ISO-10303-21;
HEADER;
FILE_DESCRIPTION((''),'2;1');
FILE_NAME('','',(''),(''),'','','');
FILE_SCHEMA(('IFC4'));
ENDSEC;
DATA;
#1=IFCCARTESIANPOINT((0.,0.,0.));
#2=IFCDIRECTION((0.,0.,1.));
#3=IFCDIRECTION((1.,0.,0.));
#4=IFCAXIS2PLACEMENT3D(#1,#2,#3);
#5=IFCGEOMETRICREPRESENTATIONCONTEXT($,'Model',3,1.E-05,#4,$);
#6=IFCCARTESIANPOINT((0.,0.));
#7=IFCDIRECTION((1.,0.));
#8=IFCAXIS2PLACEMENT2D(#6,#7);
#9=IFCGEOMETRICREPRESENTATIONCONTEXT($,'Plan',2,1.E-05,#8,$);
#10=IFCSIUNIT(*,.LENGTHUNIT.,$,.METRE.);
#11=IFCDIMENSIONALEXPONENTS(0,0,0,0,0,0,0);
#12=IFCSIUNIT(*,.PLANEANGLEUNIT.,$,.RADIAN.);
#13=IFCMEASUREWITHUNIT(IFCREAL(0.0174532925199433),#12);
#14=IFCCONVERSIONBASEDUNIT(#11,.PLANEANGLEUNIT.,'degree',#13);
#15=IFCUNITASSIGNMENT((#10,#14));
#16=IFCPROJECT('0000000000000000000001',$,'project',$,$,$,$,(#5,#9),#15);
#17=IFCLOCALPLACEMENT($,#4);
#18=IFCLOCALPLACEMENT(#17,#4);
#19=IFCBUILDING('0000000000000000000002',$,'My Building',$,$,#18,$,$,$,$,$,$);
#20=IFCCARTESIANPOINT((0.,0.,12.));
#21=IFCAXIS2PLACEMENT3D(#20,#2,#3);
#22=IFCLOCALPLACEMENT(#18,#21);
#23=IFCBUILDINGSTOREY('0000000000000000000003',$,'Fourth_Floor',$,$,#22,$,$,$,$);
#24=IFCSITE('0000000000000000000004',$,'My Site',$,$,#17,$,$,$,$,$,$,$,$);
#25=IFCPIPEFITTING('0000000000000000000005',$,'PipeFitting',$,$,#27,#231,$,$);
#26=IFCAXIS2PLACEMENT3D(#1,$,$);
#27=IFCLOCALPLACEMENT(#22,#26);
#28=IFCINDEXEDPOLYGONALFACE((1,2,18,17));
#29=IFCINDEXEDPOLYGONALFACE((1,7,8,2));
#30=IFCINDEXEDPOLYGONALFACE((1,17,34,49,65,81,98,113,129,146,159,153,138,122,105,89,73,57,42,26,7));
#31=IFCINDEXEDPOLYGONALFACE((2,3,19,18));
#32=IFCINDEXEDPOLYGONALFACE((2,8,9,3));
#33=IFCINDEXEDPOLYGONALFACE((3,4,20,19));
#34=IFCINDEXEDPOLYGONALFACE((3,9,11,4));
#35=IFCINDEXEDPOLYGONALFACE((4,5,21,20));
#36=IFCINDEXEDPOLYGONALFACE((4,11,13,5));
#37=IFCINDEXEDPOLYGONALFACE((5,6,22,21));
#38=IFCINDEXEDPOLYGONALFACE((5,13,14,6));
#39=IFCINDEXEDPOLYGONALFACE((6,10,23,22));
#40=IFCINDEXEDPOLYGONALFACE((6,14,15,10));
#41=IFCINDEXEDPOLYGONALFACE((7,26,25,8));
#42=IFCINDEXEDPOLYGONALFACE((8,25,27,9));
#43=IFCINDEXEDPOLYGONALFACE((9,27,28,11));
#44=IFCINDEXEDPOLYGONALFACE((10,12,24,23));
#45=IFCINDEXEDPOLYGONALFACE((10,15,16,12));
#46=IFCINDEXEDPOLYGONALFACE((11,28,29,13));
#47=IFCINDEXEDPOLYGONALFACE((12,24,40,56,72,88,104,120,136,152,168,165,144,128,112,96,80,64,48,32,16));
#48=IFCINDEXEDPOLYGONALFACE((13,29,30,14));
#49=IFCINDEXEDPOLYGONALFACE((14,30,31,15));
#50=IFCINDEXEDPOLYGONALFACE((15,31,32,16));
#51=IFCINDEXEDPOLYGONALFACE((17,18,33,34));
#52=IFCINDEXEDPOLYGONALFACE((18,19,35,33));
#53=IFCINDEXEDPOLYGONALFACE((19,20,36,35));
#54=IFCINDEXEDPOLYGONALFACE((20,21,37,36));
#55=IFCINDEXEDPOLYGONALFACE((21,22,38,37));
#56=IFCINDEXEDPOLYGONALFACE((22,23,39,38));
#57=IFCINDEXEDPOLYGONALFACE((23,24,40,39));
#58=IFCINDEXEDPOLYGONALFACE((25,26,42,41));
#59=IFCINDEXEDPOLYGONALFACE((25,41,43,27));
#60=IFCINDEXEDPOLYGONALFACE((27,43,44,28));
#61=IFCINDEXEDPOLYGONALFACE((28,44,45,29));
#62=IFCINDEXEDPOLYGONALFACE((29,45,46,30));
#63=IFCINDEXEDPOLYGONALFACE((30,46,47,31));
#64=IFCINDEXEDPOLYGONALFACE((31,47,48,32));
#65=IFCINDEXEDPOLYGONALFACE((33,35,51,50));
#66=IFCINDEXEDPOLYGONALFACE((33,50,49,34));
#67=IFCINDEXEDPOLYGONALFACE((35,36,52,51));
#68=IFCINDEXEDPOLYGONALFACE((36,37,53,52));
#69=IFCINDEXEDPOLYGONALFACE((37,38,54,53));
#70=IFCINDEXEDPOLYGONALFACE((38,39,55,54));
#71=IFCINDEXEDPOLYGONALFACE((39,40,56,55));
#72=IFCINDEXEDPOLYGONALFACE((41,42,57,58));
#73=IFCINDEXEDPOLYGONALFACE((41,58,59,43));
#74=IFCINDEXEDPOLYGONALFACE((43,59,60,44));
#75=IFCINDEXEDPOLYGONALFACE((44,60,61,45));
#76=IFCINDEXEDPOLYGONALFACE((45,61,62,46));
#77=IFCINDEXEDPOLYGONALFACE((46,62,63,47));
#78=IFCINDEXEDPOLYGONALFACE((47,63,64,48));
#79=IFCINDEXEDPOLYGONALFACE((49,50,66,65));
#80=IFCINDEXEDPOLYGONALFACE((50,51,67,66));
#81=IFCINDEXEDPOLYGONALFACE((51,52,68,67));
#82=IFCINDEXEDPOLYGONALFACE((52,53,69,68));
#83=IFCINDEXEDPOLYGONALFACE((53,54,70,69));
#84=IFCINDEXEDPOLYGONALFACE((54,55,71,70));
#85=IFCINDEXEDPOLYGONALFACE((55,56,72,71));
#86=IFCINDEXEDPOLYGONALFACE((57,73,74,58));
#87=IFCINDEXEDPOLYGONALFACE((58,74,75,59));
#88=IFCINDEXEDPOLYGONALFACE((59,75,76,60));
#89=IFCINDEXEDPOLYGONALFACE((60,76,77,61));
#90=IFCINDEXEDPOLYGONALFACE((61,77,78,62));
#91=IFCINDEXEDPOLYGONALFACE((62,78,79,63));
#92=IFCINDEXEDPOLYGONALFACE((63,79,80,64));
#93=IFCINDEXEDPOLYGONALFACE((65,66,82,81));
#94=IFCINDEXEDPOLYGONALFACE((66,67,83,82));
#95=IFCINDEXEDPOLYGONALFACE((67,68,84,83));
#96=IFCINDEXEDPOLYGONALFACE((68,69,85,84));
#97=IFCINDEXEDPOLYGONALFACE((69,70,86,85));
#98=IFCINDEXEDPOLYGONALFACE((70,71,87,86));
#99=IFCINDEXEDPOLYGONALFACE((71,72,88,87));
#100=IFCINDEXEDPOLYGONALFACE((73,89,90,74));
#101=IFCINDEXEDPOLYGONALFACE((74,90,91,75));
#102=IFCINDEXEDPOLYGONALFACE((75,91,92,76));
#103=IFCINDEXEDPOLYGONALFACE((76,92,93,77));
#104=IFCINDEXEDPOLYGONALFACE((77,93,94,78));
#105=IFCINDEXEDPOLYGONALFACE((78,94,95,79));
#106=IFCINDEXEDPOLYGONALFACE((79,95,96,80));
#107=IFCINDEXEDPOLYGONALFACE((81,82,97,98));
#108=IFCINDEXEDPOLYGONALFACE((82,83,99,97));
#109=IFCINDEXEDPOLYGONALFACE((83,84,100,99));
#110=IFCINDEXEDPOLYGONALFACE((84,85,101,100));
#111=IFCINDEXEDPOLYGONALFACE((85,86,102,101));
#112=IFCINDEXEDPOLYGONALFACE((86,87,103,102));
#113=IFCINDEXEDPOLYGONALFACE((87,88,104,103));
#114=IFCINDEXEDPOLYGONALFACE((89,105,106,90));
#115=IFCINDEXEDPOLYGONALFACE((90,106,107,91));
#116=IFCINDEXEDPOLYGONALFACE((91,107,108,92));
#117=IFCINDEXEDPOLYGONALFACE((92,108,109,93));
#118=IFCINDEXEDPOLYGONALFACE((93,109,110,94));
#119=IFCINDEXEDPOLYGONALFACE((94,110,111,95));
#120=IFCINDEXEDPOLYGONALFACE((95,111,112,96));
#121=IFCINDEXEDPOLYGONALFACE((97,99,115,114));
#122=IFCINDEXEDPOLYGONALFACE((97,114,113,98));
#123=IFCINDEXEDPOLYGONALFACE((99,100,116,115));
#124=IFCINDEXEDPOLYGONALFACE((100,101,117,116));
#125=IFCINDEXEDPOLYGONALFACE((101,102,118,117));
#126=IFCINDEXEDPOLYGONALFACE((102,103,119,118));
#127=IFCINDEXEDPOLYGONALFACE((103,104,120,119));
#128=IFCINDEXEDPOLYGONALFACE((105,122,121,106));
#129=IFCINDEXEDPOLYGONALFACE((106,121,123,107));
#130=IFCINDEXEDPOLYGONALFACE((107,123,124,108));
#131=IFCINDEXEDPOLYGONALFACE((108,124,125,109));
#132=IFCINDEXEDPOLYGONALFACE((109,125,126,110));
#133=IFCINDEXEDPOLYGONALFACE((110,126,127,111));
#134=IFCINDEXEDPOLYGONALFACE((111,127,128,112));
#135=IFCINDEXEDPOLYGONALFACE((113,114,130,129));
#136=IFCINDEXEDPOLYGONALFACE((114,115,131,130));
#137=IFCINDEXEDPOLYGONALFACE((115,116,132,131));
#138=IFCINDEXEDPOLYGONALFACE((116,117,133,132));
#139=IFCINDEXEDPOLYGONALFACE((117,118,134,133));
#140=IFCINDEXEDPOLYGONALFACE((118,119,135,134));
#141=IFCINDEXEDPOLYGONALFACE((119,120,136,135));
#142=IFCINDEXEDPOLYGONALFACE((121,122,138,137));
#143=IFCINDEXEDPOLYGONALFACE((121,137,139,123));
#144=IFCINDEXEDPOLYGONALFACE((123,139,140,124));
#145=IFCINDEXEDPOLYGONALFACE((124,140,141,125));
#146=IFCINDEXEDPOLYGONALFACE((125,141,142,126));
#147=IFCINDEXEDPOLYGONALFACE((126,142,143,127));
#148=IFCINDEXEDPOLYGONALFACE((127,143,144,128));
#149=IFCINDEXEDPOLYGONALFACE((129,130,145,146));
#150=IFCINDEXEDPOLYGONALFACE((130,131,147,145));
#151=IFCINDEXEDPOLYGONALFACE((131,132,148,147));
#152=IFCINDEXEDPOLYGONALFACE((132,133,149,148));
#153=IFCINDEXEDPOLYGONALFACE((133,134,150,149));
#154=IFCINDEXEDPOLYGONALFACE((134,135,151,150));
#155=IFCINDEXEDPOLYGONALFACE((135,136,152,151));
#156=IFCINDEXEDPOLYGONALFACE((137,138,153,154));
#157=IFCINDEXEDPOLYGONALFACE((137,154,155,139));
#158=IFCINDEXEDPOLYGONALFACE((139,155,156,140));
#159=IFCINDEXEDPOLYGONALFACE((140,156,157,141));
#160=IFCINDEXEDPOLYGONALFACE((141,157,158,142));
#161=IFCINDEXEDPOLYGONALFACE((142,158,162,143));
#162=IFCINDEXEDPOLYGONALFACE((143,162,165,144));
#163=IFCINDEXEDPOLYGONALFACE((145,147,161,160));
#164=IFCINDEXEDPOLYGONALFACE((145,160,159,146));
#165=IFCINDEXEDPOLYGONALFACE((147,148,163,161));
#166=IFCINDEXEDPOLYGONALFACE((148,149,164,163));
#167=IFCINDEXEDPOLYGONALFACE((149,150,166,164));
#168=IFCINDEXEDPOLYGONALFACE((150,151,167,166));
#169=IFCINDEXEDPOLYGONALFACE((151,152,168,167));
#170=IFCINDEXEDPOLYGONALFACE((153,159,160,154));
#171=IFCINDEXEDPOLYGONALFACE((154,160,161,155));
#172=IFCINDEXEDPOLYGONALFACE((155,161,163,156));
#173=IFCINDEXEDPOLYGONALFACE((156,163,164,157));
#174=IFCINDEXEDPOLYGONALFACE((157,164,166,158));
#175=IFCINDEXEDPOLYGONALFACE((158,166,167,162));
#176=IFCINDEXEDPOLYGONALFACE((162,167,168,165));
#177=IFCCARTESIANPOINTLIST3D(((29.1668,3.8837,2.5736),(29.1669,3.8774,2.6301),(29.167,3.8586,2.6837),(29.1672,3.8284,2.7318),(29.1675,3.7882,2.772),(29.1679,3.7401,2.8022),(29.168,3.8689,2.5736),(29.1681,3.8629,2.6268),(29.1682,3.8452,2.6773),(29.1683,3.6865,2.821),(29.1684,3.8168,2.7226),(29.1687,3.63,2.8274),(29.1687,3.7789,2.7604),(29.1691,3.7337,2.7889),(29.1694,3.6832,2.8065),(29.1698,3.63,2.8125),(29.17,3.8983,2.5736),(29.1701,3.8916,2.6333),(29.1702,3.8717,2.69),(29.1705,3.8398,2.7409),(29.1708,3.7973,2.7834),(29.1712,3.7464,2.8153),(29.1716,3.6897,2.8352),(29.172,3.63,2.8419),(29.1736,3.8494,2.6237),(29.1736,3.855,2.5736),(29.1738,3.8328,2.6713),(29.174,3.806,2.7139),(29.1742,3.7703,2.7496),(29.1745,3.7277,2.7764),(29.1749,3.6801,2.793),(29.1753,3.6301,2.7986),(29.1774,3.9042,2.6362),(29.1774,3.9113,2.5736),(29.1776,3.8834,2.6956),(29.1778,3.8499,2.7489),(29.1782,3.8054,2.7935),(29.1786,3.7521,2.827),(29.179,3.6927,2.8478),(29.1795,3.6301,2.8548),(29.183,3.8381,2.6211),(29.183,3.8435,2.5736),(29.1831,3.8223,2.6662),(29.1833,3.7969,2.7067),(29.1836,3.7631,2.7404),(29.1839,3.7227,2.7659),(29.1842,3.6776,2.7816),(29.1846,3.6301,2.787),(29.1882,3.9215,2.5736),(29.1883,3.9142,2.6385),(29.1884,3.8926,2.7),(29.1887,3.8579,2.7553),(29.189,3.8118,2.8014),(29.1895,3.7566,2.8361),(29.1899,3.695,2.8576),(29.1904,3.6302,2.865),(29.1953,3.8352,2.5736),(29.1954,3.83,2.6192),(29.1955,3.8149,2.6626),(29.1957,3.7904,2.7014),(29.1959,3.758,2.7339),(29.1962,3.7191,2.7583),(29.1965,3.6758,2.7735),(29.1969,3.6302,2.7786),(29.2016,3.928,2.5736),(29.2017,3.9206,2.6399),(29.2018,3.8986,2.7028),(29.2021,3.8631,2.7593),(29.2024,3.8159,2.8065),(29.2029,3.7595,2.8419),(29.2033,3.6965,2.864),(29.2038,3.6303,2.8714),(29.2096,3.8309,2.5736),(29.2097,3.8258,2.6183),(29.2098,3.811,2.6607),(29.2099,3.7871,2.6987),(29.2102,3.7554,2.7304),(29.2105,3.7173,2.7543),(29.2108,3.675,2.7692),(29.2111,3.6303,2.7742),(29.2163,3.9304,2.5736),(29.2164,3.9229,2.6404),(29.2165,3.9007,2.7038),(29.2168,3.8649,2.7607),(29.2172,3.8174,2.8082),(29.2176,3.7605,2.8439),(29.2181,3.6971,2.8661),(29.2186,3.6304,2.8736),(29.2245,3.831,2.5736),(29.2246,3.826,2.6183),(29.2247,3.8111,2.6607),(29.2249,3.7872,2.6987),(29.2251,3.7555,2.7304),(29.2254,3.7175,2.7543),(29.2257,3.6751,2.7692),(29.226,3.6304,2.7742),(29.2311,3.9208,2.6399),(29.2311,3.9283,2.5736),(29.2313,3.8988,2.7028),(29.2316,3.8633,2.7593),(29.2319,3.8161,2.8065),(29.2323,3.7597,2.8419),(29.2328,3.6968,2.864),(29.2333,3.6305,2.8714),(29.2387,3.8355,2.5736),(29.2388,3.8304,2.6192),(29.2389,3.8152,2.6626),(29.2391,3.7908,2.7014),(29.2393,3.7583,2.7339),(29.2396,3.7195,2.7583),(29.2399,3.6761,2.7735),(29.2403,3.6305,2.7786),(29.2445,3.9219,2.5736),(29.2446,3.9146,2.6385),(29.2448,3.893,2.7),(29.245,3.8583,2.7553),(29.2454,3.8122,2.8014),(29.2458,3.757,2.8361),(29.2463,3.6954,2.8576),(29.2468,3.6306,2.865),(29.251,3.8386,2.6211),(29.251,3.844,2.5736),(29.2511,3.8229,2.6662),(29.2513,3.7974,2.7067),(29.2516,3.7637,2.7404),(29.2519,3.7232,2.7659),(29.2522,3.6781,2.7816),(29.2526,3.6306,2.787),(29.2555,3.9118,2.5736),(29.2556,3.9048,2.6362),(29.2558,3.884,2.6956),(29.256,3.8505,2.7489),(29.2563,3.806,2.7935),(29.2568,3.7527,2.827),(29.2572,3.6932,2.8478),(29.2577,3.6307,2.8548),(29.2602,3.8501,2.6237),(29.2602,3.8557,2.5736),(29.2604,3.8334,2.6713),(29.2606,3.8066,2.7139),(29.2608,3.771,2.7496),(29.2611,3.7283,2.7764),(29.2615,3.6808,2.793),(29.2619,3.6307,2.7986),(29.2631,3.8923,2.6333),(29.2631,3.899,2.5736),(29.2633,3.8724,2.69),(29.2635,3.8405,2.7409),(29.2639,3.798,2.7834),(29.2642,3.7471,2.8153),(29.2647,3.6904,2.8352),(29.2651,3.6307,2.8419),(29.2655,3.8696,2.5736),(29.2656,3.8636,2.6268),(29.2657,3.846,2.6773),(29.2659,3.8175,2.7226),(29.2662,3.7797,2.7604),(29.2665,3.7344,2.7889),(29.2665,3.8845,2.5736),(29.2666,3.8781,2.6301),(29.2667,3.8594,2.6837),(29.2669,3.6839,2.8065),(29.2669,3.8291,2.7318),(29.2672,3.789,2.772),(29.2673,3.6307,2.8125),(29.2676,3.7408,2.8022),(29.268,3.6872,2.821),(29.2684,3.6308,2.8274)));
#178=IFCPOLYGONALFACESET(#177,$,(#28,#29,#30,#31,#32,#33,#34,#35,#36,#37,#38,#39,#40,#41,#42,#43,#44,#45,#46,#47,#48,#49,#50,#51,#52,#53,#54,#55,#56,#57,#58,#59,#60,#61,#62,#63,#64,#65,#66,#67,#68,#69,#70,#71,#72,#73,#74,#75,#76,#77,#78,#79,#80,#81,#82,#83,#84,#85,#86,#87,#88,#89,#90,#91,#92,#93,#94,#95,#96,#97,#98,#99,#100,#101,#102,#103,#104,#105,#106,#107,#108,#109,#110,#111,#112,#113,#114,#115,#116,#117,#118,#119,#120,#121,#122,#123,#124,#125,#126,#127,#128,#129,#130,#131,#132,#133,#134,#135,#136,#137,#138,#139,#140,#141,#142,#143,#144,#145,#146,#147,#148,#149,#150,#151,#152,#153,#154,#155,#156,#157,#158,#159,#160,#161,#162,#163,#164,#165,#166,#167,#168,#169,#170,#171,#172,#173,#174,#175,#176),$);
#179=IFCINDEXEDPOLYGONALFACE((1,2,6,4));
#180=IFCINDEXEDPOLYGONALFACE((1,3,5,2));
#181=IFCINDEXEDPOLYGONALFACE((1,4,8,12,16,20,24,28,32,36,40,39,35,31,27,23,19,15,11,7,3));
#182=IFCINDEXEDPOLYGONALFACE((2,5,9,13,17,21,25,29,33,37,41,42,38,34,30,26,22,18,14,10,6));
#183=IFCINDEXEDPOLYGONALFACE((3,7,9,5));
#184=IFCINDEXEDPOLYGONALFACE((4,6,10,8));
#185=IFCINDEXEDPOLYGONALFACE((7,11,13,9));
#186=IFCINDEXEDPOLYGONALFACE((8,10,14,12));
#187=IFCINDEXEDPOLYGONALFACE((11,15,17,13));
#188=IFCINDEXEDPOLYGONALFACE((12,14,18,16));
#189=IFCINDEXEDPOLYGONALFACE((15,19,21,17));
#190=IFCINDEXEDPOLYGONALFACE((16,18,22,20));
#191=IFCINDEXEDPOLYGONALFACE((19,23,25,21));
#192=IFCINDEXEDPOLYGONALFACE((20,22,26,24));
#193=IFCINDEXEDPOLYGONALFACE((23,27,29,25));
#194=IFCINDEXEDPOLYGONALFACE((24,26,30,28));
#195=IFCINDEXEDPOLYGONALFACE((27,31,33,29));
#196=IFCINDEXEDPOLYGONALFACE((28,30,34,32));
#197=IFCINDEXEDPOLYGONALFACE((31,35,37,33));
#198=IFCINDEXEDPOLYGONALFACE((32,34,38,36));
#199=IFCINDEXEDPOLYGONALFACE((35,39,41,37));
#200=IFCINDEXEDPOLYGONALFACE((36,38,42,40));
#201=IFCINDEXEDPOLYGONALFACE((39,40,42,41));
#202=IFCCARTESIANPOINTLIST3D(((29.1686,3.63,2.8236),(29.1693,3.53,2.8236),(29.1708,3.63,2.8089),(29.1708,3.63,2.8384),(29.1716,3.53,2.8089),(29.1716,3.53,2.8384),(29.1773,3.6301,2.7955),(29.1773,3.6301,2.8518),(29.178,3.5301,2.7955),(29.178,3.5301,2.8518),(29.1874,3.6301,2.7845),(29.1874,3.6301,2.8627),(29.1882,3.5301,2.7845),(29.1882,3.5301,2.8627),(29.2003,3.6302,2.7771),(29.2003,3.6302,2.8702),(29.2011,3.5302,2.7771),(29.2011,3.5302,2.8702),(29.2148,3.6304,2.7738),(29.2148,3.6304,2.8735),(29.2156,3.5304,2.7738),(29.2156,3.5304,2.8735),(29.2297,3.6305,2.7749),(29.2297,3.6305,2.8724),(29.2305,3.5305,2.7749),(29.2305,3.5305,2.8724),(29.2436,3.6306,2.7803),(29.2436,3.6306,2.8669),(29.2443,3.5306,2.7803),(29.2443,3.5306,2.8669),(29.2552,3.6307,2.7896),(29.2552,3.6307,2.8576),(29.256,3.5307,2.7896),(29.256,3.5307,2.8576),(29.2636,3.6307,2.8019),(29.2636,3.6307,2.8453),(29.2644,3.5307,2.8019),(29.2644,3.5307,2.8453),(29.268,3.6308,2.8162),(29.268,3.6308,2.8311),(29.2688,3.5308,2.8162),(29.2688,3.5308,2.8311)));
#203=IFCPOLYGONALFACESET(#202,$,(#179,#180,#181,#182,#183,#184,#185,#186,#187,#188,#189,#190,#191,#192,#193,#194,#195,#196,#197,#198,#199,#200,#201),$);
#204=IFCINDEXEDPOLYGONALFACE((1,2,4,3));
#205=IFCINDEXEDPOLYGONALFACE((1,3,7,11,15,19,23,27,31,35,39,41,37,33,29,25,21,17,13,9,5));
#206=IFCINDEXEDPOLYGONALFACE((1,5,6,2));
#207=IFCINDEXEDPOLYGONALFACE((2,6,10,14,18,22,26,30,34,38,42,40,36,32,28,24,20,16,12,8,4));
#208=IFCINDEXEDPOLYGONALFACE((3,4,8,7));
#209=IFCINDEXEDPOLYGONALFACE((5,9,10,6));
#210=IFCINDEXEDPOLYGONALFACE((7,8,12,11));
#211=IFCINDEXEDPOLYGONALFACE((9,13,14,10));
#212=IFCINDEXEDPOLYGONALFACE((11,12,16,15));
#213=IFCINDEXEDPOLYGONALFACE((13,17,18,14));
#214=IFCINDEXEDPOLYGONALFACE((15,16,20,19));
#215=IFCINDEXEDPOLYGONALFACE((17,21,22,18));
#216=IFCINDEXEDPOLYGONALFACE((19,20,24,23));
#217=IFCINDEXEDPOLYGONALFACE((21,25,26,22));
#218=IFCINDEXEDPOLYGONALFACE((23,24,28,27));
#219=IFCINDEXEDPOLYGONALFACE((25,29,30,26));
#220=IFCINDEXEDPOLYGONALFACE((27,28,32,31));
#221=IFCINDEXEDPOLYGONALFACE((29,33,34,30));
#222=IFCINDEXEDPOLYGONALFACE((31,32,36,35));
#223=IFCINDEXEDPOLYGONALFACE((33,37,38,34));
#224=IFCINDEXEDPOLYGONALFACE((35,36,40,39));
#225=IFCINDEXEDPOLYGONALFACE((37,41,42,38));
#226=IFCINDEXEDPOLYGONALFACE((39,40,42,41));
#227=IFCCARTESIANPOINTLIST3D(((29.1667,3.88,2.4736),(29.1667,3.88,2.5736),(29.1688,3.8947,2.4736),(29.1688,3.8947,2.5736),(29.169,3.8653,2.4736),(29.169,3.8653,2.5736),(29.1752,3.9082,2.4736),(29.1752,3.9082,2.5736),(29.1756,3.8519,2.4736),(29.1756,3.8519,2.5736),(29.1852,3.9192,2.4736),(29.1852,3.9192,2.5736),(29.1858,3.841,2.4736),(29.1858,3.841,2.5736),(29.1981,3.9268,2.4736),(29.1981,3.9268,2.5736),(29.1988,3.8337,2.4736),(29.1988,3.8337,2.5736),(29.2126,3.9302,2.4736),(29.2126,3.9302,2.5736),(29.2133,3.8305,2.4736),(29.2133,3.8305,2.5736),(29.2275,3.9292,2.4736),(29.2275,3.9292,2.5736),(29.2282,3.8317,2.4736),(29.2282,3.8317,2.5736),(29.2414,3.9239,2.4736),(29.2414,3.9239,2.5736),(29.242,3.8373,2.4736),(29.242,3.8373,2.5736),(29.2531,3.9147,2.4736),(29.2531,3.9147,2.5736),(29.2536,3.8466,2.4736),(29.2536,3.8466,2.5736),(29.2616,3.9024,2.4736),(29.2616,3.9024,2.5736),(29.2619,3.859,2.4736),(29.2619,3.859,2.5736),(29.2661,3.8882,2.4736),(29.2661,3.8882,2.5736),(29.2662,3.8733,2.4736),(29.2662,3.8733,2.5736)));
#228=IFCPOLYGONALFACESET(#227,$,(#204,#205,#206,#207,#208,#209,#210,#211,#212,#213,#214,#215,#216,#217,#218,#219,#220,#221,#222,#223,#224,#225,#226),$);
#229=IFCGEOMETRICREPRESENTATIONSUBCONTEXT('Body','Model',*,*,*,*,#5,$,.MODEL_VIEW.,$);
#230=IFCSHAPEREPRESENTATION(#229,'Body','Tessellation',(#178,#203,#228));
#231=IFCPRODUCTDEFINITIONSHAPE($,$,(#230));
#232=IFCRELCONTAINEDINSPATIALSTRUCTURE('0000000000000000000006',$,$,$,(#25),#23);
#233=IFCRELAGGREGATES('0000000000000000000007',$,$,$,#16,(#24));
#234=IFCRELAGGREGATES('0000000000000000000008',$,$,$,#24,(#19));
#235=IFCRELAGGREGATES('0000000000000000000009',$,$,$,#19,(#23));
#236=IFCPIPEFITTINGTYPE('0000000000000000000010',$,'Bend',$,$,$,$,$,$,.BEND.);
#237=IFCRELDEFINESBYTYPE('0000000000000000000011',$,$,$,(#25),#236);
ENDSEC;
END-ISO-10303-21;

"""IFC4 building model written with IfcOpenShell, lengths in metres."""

from ifc_helpers import new_model, entity, si_unit, converted_unit, frame, origin_with_axes, origin_2d_with_axis, place, context, subcontext, project, spatial, circle, extrude, source, transform, mapped, type_object, type_shapes, element, save


model = new_model("IFC4")

# Units and contexts
model_context = context("Model", 3, precision=1e-05, world=origin_with_axes())
plan_context = context("Plan", 2, precision=1e-05, world=origin_2d_with_axis())
body_context_1 = subcontext(model_context, "Body", "Model", "MODEL_VIEW")
ifc_project = project(units=[si_unit("LENGTHUNIT", "METRE"), converted_unit("PLANEANGLEUNIT", "degree", entity("IfcReal", 0.0174532925199433), si_unit("PLANEANGLEUNIT", "RADIAN"), dimensions=[0, 0, 0, 0, 0, 0, 0])], contexts=[model_context, plan_context])

# Site, building, storey
site_placement = place(None, origin_with_axes())
site = spatial("IfcSite", under=ifc_project, at=site_placement, Name="My Site")
building_placement = place(site_placement, origin_with_axes())
building = spatial("IfcBuilding", under=site, at=building_placement, Name="My Building")
storey_placement = place(building_placement, frame((0.0, 0.0, 12.0), z_axis=(0.0, 0.0, 1.0), x_axis=(1.0, 0.0, 0.0)))
storey = spatial("IfcBuildingStorey", under=building, at=storey_placement, Name="Fourth_Floor")

# Pipe fitting
pipe_fitting_type = type_object("IfcPipeFittingType", Name="Bend", PredefinedType="BEND")
shared_shape_1 = source(origin_with_axes(), body_context_1, "Body", "SolidModel", [
    entity("IfcSweptDiskSolid", entity("IfcIndexedPolyCurve", entity("IfcCartesianPointList3D", [[0.0, 0.0, -0.1], [0.0, 0.0732, -0.2768], [0.0, 0.25, -0.35]]), [entity("IfcArcIndex", [1, 2, 3])]), 0.05),
    extrude(circle(Radius=0.05), origin_with_axes(), (0.0, 0.0, -1.0), 0.1),
    extrude(circle(Radius=0.05), frame((0.0, 0.25, -0.35), z_axis=(0.0, 1.0, 0.0), x_axis=(1.0, 0.0, 0.0)), (0.0, 0.0, 1.0), 0.1),
])
type_shapes(pipe_fitting_type, [shared_shape_1])
for number, where, z_axis, x_axis, name in (
    (1, (29.2193, 3.5304, 2.8236), (0.007564, -0.999971, 0.0), (-0.999971, -0.007564, 0.0), "PipeFitting"),
):
    element("IfcPipeFitting", number, at=place(storey_placement, frame(where, z_axis=z_axis, x_axis=x_axis)), inside=storey, type_object=pipe_fitting_type, Name=name, context=body_context_1, shape_type="MappedRepresentation", body=[
        mapped(shared_shape_1, transform((0.0, 0.0, 0.0), x_axis=(1.0, 0.0, 0.0), y_axis=(0.0, 1.0, 0.0), z_axis=(0.0, 0.0, 1.0), scale=1.0)),
    ])

save(model, "model.ifc")
